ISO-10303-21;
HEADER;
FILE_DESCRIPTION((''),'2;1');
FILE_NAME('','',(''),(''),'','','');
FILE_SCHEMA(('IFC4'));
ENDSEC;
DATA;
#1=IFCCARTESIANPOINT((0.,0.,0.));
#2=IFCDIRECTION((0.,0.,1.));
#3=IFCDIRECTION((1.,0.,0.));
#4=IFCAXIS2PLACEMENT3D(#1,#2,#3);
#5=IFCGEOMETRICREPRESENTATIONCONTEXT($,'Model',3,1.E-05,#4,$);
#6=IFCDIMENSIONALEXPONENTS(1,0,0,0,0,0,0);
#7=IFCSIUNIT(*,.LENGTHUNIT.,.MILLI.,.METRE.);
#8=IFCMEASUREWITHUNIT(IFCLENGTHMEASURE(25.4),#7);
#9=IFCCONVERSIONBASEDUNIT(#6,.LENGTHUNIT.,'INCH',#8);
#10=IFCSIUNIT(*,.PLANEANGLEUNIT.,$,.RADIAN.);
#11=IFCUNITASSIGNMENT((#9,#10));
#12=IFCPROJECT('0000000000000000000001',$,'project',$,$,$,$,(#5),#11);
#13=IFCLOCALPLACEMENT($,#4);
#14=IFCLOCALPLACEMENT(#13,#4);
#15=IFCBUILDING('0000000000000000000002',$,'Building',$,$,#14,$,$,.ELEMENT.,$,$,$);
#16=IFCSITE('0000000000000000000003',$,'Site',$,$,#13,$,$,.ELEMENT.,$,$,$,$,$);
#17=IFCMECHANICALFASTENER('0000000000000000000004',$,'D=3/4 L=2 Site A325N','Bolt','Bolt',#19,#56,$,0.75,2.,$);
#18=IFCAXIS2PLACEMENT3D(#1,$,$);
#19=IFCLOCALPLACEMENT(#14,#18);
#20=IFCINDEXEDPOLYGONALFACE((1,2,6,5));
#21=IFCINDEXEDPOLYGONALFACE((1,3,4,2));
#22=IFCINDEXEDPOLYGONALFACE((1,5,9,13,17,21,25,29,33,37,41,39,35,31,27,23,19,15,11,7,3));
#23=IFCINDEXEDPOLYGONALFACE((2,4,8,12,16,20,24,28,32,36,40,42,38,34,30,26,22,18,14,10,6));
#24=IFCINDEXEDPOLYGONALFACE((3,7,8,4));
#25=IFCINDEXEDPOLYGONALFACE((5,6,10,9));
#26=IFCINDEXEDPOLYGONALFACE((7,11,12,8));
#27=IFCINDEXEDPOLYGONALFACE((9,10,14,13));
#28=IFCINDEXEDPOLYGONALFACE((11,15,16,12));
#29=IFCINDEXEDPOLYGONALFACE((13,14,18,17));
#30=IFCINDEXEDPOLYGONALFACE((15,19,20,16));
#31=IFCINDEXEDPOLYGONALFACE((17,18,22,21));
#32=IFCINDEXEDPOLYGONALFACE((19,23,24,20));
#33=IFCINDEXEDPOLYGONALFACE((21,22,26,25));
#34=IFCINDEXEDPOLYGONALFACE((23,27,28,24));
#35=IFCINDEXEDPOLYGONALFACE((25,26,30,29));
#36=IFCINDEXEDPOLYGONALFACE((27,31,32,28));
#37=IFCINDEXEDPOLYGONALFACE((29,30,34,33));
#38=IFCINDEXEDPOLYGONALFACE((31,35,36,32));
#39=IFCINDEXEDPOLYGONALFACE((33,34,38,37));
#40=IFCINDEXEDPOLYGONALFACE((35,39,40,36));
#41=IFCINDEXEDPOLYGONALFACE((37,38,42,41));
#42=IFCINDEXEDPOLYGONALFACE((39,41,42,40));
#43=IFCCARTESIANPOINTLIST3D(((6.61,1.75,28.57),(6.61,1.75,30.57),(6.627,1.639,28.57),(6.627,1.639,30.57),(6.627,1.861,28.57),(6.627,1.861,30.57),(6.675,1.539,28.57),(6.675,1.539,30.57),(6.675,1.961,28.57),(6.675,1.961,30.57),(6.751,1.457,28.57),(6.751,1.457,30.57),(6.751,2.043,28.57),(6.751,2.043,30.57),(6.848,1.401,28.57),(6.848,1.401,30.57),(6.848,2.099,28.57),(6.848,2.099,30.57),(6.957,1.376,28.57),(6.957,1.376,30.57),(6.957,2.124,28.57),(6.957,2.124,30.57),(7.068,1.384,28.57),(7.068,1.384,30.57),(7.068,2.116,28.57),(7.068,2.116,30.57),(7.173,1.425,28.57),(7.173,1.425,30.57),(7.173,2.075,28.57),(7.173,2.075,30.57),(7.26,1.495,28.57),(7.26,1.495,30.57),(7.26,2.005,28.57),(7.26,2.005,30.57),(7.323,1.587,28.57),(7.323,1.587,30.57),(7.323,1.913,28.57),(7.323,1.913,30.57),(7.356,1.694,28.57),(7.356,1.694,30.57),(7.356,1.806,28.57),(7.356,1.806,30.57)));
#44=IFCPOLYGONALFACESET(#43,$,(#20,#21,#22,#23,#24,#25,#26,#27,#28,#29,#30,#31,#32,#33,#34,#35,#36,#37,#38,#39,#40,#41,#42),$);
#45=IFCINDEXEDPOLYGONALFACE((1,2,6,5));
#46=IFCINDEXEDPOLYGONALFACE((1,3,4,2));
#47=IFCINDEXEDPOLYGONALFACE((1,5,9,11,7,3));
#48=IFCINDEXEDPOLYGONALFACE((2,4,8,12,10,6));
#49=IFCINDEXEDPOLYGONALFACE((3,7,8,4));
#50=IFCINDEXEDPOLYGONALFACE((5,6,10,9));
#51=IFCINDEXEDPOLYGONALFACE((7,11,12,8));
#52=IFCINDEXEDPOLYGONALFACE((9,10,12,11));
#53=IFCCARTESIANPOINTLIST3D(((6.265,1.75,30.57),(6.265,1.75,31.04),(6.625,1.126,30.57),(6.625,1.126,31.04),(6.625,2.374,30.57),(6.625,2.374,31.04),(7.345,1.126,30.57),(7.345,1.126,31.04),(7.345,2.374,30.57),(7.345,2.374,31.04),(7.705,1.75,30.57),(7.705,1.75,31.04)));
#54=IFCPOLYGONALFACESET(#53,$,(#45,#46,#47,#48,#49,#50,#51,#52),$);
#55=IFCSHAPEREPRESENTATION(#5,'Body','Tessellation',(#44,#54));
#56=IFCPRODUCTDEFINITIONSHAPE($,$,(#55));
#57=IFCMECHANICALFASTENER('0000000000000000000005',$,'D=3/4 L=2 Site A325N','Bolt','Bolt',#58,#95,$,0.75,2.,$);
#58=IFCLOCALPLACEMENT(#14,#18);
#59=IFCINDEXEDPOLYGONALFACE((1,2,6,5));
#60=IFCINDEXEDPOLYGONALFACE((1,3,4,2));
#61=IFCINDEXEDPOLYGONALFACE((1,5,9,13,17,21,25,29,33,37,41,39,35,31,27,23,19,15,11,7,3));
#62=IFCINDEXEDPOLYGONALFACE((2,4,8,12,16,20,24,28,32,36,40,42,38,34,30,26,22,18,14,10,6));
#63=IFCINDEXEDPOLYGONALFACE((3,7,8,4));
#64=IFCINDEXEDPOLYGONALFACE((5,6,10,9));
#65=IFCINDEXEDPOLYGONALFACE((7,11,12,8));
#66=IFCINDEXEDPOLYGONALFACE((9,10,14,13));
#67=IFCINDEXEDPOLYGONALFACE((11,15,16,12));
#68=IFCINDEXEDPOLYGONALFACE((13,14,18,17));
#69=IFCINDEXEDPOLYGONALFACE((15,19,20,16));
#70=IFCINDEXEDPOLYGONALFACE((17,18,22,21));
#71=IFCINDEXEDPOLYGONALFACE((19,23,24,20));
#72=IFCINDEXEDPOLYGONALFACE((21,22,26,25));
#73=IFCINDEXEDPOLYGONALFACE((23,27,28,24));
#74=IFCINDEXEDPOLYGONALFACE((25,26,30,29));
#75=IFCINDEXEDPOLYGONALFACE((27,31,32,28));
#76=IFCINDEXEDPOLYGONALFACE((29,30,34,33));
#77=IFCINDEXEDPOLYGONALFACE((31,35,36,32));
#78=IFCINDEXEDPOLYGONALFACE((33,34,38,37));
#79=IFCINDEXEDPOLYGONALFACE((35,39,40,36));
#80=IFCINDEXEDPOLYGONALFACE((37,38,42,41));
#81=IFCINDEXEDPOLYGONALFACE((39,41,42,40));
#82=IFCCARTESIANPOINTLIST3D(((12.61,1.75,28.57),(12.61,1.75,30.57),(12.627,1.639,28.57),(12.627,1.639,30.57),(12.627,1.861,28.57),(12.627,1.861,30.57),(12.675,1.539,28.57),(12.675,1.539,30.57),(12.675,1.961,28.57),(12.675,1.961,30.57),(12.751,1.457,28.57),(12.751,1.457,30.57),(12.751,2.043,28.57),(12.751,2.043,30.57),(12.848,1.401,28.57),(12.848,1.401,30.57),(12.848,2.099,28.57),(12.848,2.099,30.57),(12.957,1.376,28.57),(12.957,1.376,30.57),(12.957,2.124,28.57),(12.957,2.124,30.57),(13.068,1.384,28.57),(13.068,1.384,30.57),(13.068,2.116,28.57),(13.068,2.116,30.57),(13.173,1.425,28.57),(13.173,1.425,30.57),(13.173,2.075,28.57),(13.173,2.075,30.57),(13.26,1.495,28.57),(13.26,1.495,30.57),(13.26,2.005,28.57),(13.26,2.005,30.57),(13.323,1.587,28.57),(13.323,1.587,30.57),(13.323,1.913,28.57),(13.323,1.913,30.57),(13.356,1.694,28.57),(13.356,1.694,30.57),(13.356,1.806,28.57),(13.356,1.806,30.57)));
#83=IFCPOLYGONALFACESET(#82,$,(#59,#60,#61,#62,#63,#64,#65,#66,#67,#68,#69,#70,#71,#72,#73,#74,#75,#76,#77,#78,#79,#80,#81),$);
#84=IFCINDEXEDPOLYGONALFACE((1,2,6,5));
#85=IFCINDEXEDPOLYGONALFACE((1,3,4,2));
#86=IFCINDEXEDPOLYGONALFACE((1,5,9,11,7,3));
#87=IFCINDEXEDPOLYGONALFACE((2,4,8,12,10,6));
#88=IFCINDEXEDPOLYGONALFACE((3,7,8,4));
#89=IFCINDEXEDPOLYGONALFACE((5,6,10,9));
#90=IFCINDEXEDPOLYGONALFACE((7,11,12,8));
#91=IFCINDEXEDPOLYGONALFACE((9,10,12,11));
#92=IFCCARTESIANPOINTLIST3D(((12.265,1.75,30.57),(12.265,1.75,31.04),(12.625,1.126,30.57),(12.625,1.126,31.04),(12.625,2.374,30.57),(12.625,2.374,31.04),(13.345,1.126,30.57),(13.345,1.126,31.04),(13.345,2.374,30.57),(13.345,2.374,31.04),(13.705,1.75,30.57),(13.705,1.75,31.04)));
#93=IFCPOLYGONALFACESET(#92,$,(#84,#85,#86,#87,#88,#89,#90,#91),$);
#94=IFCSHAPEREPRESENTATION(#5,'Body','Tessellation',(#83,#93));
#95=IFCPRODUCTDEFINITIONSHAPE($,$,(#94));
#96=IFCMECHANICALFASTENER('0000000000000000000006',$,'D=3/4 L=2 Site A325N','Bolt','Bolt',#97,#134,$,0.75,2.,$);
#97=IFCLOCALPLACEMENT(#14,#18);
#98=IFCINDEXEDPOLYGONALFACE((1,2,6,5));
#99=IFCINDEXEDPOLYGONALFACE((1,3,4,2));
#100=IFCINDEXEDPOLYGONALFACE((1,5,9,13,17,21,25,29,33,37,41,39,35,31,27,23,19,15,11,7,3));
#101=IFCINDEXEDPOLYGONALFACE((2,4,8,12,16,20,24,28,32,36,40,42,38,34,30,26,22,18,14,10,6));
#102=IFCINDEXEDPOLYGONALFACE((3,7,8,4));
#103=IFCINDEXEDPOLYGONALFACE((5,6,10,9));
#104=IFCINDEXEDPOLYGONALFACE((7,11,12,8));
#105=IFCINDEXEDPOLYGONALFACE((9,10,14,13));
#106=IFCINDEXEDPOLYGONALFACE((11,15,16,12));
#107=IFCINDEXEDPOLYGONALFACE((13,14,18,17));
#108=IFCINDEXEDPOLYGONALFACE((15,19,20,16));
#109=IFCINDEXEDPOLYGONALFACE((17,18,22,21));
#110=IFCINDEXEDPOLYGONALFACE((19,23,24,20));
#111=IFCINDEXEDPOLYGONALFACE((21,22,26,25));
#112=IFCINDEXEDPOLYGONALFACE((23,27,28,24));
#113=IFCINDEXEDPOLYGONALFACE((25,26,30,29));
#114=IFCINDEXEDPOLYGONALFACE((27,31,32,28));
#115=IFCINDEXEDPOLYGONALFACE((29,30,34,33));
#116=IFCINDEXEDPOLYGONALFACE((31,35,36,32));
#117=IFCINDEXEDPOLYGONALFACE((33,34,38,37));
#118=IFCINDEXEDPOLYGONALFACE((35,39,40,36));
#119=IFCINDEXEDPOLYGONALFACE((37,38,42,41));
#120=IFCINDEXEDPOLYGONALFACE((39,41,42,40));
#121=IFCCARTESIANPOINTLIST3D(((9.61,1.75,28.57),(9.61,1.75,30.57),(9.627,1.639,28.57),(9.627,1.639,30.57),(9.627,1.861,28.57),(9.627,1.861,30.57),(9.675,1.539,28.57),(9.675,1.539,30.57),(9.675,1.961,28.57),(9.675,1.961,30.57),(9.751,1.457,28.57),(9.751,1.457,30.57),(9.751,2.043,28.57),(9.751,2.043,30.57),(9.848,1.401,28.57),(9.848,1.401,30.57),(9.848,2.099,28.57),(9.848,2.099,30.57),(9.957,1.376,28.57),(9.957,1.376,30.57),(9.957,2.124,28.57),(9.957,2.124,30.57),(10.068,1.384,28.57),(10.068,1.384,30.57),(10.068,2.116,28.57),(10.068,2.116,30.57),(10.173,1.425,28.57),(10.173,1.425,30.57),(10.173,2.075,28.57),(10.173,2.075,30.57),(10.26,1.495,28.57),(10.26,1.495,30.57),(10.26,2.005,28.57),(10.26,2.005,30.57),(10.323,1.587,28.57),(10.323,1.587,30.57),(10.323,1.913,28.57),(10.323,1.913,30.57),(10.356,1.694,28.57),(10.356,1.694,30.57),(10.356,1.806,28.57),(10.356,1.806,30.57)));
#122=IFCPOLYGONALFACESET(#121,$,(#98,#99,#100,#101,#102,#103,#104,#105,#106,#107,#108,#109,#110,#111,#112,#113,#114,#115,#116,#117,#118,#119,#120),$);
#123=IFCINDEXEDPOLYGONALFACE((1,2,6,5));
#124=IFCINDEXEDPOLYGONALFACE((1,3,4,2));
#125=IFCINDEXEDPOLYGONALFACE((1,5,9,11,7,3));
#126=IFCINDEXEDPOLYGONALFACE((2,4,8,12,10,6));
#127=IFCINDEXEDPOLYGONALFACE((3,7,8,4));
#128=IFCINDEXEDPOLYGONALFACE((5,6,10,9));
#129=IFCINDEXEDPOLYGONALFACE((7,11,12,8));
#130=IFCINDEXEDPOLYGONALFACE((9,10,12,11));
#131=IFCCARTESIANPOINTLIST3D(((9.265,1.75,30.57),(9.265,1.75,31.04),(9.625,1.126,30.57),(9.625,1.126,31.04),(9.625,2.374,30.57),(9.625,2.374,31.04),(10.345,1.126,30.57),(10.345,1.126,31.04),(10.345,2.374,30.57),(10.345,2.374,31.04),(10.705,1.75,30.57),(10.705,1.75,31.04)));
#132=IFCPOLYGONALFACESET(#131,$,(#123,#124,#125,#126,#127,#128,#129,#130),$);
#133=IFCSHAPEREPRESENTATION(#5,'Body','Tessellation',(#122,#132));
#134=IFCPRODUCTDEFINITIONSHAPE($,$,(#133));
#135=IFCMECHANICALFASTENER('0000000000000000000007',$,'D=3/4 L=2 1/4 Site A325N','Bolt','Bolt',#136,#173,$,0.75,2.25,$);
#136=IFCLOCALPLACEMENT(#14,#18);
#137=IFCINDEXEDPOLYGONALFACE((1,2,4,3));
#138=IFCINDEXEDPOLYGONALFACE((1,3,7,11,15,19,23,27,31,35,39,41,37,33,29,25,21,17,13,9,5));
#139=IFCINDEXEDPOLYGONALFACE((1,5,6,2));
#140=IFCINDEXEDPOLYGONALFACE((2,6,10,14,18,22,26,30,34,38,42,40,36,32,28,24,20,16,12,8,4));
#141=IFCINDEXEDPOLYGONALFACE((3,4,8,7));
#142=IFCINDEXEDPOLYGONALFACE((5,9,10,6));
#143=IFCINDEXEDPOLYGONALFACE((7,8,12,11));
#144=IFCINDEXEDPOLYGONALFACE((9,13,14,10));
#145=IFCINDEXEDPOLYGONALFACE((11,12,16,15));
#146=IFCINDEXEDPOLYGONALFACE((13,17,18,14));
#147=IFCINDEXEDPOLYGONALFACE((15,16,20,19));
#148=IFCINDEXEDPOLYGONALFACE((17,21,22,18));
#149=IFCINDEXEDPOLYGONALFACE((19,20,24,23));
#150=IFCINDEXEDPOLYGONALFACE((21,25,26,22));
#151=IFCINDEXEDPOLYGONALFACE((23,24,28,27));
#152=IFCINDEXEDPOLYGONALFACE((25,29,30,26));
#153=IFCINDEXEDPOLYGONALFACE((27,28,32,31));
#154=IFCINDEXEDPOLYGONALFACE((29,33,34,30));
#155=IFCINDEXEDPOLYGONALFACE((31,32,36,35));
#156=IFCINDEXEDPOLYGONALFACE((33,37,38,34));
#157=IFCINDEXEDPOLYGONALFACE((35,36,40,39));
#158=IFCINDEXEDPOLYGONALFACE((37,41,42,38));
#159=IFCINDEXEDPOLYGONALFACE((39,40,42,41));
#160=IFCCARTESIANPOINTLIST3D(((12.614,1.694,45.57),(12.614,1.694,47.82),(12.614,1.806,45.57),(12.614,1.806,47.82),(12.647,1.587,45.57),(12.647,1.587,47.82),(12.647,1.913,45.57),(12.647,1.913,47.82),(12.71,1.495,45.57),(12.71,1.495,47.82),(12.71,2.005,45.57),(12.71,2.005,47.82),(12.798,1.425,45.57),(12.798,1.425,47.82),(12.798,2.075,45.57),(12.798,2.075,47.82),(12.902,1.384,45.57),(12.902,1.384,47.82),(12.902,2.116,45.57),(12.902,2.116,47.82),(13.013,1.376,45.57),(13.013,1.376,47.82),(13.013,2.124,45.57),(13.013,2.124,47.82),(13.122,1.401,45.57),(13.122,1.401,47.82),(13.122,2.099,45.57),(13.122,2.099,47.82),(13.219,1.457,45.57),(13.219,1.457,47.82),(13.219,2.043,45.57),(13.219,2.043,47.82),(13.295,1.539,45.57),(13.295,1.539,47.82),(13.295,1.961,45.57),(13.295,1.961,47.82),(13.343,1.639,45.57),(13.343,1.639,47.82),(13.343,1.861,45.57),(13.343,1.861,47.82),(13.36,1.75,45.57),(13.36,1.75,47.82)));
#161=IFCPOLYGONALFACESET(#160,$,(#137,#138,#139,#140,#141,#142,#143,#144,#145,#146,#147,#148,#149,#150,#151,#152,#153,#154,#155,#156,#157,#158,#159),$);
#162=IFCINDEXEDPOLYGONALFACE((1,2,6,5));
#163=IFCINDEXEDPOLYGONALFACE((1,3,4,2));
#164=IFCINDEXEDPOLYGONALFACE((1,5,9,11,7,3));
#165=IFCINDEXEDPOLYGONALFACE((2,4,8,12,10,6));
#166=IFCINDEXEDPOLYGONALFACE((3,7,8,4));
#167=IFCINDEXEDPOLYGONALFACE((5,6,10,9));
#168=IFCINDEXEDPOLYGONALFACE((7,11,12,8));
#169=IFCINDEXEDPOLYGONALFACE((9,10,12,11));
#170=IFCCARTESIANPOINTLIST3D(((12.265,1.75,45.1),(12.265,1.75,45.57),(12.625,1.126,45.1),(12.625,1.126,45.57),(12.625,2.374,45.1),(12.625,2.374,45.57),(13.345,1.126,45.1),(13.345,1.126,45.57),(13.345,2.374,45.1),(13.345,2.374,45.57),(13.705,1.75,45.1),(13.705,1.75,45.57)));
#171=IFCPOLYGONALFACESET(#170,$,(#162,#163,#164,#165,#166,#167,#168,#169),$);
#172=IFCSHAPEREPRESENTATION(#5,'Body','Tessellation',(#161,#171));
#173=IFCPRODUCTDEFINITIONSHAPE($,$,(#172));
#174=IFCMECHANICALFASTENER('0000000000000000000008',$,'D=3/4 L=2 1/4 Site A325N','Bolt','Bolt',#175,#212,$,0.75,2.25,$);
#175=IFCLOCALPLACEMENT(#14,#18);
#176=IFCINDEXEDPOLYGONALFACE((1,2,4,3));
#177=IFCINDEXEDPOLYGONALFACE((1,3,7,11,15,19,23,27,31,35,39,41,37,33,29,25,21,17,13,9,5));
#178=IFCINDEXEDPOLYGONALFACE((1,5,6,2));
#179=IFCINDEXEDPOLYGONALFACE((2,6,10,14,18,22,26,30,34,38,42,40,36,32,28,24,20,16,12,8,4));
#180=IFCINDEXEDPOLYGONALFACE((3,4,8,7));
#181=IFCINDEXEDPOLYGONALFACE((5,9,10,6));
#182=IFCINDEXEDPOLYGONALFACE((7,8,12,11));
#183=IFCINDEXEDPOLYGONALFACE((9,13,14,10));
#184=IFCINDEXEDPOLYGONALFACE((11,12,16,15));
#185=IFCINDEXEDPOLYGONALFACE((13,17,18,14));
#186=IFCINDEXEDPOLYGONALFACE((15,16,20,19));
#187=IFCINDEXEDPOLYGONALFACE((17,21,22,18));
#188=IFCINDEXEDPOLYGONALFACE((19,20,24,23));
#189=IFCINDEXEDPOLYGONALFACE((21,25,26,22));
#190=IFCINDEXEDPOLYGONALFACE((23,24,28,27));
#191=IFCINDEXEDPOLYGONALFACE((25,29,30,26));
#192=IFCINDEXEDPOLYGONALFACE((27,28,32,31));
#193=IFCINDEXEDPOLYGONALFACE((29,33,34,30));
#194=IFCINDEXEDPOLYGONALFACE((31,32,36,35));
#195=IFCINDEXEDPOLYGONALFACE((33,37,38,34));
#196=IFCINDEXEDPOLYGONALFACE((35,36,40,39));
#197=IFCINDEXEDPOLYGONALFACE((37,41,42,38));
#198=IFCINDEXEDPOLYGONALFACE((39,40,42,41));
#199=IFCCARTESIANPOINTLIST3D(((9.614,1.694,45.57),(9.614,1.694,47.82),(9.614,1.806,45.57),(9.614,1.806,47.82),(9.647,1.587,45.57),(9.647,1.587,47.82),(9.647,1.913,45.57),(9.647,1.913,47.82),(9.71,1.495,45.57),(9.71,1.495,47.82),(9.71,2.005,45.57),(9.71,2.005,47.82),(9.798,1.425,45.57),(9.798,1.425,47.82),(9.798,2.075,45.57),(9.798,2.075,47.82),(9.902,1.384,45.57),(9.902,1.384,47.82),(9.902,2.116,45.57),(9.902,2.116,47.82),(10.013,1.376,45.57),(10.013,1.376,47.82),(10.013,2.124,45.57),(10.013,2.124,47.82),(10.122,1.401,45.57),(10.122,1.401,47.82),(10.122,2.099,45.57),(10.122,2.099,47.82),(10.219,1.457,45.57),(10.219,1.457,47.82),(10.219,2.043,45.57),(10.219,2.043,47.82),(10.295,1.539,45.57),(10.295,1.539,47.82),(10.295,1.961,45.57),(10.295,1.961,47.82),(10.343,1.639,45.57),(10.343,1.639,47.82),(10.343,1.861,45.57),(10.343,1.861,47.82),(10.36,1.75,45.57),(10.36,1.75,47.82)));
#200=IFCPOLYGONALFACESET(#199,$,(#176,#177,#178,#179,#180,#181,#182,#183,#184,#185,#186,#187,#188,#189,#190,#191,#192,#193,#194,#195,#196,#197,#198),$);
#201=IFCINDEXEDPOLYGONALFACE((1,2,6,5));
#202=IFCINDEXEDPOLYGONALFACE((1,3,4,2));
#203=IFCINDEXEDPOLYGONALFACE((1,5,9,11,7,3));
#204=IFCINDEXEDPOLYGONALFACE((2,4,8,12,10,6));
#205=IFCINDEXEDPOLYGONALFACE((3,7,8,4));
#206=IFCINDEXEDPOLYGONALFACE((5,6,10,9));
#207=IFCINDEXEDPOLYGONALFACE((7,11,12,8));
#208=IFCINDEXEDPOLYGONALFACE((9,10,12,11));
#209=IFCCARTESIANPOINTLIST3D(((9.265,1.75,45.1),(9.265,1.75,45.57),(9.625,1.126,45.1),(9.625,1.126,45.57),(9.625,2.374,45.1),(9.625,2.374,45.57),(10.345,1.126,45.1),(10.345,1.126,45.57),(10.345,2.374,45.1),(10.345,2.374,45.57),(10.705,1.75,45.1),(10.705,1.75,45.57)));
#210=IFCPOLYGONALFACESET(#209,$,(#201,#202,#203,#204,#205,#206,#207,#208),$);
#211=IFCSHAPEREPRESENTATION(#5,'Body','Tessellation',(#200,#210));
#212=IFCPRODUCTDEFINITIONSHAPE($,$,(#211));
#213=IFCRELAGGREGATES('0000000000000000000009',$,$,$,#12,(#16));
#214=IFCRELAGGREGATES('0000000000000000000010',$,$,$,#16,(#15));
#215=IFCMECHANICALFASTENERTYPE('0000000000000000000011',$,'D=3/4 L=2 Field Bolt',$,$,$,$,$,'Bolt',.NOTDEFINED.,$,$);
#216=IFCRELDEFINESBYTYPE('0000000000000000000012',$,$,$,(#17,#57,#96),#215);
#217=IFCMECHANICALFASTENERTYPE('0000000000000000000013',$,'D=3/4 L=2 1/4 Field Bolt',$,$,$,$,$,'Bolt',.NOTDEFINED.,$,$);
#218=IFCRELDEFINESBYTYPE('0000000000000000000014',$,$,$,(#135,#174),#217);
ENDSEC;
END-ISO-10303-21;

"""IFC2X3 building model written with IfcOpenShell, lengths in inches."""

from ifc_helpers import new_model, entity, si_unit, converted_unit, frame, origin_with_axes, origin_2d_with_axis, place, context, project, spatial, polyline, circle, outline, extrude, source, transform, mapped, type_object, type_shapes, element, save


model = new_model("IFC2X3")

# Units and contexts
model_context = context("Model", 3, precision=1e-05, world=origin_with_axes())
ifc_project = project(units=[converted_unit("LENGTHUNIT", "INCH", entity("IfcLengthMeasure", 25.4), si_unit("LENGTHUNIT", "METRE", prefix="MILLI"), dimensions=[1, 0, 0, 0, 0, 0, 0]), si_unit("PLANEANGLEUNIT", "RADIAN")], contexts=[model_context])

# Site, building
site_placement = place(None, origin_with_axes())
site = spatial("IfcSite", under=ifc_project, at=site_placement, Name="Site", CompositionType="ELEMENT")
building_placement = place(site_placement, origin_with_axes())
building = spatial("IfcBuilding", under=site, at=building_placement, Name="Building", CompositionType="ELEMENT")

# Mechanical fasteners
placement_1 = place(building_placement, frame((0.0, 0.0, 46.0), z_axis=(0.0, 0.0, 1.0), x_axis=(1.0, 0.0, 0.0)))
mechanical_fastener_type_1 = type_object("IfcMechanicalFastenerType", Name="D=3/4 L=2 Field Bolt", ElementType="Bolt")
shared_shape_1 = source(origin_with_axes(), model_context, "Body", "SweptSolid", [
    extrude(circle(Radius=0.375, at=origin_2d_with_axis()), frame((0.0, 0.0, 0.0), z_axis=(1.0, 0.0, 0.0), x_axis=(0.0, 1.0, 0.0)), (0.0, 0.0, 1.0), 2.0),
    extrude(outline(polyline([(-0.72, 0.0), (-0.36, 0.624), (0.36, 0.624), (0.72, 0.0), (0.36, -0.624), (-0.36, -0.624), (-0.72, 0.0)])), frame((0.0, 0.0, 0.0), z_axis=(1.0, 0.0, 0.0), x_axis=(0.0, 1.0, 0.0)), (0.0, 0.0, -1.0), 0.47),
])
type_shapes(mechanical_fastener_type_1, [shared_shape_1])
placement_2 = place(placement_1, frame((6.985, 1.75, -15.43), z_axis=(0.0, 1.0, 0.0), x_axis=(0.0, 0.0, -1.0)))
for number, where, z_axis, x_axis, name in (
    (1, (0.0, 0.0, 0.0), (0.0, 0.0, 1.0), (1.0, 0.0, 0.0), "D=3/4 L=2 Site A325N"),
    (2, (0.0, -6.0, 0.0), (0.0, 0.0, 1.0), (1.0, 0.0, 0.0), "D=3/4 L=2 Site A325N"),
    (3, (0.0, -3.0, 0.0), (0.0, 0.0, 1.0), (1.0, 0.0, 0.0), "D=3/4 L=2 Site A325N"),
):
    element("IfcMechanicalFastener", number, at=place(placement_2, frame(where, z_axis=z_axis, x_axis=x_axis)), type_object=mechanical_fastener_type_1, Name=name, Description="Bolt", ObjectType="Bolt", NominalDiameter=0.75, NominalLength=2.0, context=model_context, shape_type="MappedRepresentation", body=[
        mapped(shared_shape_1, transform((0.0, 0.0, 0.0), scale=1.0)),
    ])
mechanical_fastener_type_2 = type_object("IfcMechanicalFastenerType", Name="D=3/4 L=2 1/4 Field Bolt", ElementType="Bolt")
shared_shape_2 = source(origin_with_axes(), model_context, "Body", "SweptSolid", [
    extrude(circle(Radius=0.375, at=origin_2d_with_axis()), frame((0.0, 0.0, 0.0), z_axis=(1.0, 0.0, 0.0), x_axis=(0.0, 1.0, 0.0)), (0.0, 0.0, 1.0), 2.25),
    extrude(outline(polyline([(-0.72, 0.0), (-0.36, 0.624), (0.36, 0.624), (0.72, 0.0), (0.36, -0.624), (-0.36, -0.624), (-0.72, 0.0)])), frame((0.0, 0.0, 0.0), z_axis=(1.0, 0.0, 0.0), x_axis=(0.0, 1.0, 0.0)), (0.0, 0.0, -1.0), 0.47),
])
type_shapes(mechanical_fastener_type_2, [shared_shape_2])
placement_3 = place(placement_1, frame((6.985, 1.75, -0.43), z_axis=(0.0, 1.0, 0.0), x_axis=(0.0, 0.0, 1.0)))
for number, where, z_axis, x_axis, name in (
    (4, (0.0, 6.0, 0.0), (0.0, 0.0, 1.0), (1.0, 0.0, 0.0), "D=3/4 L=2 1/4 Site A325N"),
    (5, (0.0, 3.0, 0.0), (0.0, 0.0, 1.0), (1.0, 0.0, 0.0), "D=3/4 L=2 1/4 Site A325N"),
):
    element("IfcMechanicalFastener", number, at=place(placement_3, frame(where, z_axis=z_axis, x_axis=x_axis)), type_object=mechanical_fastener_type_2, Name=name, Description="Bolt", ObjectType="Bolt", NominalDiameter=0.75, NominalLength=2.25, context=model_context, shape_type="MappedRepresentation", body=[
        mapped(shared_shape_2, transform((0.0, 0.0, 0.0), scale=1.0)),
    ])

save(model, "model.ifc")
